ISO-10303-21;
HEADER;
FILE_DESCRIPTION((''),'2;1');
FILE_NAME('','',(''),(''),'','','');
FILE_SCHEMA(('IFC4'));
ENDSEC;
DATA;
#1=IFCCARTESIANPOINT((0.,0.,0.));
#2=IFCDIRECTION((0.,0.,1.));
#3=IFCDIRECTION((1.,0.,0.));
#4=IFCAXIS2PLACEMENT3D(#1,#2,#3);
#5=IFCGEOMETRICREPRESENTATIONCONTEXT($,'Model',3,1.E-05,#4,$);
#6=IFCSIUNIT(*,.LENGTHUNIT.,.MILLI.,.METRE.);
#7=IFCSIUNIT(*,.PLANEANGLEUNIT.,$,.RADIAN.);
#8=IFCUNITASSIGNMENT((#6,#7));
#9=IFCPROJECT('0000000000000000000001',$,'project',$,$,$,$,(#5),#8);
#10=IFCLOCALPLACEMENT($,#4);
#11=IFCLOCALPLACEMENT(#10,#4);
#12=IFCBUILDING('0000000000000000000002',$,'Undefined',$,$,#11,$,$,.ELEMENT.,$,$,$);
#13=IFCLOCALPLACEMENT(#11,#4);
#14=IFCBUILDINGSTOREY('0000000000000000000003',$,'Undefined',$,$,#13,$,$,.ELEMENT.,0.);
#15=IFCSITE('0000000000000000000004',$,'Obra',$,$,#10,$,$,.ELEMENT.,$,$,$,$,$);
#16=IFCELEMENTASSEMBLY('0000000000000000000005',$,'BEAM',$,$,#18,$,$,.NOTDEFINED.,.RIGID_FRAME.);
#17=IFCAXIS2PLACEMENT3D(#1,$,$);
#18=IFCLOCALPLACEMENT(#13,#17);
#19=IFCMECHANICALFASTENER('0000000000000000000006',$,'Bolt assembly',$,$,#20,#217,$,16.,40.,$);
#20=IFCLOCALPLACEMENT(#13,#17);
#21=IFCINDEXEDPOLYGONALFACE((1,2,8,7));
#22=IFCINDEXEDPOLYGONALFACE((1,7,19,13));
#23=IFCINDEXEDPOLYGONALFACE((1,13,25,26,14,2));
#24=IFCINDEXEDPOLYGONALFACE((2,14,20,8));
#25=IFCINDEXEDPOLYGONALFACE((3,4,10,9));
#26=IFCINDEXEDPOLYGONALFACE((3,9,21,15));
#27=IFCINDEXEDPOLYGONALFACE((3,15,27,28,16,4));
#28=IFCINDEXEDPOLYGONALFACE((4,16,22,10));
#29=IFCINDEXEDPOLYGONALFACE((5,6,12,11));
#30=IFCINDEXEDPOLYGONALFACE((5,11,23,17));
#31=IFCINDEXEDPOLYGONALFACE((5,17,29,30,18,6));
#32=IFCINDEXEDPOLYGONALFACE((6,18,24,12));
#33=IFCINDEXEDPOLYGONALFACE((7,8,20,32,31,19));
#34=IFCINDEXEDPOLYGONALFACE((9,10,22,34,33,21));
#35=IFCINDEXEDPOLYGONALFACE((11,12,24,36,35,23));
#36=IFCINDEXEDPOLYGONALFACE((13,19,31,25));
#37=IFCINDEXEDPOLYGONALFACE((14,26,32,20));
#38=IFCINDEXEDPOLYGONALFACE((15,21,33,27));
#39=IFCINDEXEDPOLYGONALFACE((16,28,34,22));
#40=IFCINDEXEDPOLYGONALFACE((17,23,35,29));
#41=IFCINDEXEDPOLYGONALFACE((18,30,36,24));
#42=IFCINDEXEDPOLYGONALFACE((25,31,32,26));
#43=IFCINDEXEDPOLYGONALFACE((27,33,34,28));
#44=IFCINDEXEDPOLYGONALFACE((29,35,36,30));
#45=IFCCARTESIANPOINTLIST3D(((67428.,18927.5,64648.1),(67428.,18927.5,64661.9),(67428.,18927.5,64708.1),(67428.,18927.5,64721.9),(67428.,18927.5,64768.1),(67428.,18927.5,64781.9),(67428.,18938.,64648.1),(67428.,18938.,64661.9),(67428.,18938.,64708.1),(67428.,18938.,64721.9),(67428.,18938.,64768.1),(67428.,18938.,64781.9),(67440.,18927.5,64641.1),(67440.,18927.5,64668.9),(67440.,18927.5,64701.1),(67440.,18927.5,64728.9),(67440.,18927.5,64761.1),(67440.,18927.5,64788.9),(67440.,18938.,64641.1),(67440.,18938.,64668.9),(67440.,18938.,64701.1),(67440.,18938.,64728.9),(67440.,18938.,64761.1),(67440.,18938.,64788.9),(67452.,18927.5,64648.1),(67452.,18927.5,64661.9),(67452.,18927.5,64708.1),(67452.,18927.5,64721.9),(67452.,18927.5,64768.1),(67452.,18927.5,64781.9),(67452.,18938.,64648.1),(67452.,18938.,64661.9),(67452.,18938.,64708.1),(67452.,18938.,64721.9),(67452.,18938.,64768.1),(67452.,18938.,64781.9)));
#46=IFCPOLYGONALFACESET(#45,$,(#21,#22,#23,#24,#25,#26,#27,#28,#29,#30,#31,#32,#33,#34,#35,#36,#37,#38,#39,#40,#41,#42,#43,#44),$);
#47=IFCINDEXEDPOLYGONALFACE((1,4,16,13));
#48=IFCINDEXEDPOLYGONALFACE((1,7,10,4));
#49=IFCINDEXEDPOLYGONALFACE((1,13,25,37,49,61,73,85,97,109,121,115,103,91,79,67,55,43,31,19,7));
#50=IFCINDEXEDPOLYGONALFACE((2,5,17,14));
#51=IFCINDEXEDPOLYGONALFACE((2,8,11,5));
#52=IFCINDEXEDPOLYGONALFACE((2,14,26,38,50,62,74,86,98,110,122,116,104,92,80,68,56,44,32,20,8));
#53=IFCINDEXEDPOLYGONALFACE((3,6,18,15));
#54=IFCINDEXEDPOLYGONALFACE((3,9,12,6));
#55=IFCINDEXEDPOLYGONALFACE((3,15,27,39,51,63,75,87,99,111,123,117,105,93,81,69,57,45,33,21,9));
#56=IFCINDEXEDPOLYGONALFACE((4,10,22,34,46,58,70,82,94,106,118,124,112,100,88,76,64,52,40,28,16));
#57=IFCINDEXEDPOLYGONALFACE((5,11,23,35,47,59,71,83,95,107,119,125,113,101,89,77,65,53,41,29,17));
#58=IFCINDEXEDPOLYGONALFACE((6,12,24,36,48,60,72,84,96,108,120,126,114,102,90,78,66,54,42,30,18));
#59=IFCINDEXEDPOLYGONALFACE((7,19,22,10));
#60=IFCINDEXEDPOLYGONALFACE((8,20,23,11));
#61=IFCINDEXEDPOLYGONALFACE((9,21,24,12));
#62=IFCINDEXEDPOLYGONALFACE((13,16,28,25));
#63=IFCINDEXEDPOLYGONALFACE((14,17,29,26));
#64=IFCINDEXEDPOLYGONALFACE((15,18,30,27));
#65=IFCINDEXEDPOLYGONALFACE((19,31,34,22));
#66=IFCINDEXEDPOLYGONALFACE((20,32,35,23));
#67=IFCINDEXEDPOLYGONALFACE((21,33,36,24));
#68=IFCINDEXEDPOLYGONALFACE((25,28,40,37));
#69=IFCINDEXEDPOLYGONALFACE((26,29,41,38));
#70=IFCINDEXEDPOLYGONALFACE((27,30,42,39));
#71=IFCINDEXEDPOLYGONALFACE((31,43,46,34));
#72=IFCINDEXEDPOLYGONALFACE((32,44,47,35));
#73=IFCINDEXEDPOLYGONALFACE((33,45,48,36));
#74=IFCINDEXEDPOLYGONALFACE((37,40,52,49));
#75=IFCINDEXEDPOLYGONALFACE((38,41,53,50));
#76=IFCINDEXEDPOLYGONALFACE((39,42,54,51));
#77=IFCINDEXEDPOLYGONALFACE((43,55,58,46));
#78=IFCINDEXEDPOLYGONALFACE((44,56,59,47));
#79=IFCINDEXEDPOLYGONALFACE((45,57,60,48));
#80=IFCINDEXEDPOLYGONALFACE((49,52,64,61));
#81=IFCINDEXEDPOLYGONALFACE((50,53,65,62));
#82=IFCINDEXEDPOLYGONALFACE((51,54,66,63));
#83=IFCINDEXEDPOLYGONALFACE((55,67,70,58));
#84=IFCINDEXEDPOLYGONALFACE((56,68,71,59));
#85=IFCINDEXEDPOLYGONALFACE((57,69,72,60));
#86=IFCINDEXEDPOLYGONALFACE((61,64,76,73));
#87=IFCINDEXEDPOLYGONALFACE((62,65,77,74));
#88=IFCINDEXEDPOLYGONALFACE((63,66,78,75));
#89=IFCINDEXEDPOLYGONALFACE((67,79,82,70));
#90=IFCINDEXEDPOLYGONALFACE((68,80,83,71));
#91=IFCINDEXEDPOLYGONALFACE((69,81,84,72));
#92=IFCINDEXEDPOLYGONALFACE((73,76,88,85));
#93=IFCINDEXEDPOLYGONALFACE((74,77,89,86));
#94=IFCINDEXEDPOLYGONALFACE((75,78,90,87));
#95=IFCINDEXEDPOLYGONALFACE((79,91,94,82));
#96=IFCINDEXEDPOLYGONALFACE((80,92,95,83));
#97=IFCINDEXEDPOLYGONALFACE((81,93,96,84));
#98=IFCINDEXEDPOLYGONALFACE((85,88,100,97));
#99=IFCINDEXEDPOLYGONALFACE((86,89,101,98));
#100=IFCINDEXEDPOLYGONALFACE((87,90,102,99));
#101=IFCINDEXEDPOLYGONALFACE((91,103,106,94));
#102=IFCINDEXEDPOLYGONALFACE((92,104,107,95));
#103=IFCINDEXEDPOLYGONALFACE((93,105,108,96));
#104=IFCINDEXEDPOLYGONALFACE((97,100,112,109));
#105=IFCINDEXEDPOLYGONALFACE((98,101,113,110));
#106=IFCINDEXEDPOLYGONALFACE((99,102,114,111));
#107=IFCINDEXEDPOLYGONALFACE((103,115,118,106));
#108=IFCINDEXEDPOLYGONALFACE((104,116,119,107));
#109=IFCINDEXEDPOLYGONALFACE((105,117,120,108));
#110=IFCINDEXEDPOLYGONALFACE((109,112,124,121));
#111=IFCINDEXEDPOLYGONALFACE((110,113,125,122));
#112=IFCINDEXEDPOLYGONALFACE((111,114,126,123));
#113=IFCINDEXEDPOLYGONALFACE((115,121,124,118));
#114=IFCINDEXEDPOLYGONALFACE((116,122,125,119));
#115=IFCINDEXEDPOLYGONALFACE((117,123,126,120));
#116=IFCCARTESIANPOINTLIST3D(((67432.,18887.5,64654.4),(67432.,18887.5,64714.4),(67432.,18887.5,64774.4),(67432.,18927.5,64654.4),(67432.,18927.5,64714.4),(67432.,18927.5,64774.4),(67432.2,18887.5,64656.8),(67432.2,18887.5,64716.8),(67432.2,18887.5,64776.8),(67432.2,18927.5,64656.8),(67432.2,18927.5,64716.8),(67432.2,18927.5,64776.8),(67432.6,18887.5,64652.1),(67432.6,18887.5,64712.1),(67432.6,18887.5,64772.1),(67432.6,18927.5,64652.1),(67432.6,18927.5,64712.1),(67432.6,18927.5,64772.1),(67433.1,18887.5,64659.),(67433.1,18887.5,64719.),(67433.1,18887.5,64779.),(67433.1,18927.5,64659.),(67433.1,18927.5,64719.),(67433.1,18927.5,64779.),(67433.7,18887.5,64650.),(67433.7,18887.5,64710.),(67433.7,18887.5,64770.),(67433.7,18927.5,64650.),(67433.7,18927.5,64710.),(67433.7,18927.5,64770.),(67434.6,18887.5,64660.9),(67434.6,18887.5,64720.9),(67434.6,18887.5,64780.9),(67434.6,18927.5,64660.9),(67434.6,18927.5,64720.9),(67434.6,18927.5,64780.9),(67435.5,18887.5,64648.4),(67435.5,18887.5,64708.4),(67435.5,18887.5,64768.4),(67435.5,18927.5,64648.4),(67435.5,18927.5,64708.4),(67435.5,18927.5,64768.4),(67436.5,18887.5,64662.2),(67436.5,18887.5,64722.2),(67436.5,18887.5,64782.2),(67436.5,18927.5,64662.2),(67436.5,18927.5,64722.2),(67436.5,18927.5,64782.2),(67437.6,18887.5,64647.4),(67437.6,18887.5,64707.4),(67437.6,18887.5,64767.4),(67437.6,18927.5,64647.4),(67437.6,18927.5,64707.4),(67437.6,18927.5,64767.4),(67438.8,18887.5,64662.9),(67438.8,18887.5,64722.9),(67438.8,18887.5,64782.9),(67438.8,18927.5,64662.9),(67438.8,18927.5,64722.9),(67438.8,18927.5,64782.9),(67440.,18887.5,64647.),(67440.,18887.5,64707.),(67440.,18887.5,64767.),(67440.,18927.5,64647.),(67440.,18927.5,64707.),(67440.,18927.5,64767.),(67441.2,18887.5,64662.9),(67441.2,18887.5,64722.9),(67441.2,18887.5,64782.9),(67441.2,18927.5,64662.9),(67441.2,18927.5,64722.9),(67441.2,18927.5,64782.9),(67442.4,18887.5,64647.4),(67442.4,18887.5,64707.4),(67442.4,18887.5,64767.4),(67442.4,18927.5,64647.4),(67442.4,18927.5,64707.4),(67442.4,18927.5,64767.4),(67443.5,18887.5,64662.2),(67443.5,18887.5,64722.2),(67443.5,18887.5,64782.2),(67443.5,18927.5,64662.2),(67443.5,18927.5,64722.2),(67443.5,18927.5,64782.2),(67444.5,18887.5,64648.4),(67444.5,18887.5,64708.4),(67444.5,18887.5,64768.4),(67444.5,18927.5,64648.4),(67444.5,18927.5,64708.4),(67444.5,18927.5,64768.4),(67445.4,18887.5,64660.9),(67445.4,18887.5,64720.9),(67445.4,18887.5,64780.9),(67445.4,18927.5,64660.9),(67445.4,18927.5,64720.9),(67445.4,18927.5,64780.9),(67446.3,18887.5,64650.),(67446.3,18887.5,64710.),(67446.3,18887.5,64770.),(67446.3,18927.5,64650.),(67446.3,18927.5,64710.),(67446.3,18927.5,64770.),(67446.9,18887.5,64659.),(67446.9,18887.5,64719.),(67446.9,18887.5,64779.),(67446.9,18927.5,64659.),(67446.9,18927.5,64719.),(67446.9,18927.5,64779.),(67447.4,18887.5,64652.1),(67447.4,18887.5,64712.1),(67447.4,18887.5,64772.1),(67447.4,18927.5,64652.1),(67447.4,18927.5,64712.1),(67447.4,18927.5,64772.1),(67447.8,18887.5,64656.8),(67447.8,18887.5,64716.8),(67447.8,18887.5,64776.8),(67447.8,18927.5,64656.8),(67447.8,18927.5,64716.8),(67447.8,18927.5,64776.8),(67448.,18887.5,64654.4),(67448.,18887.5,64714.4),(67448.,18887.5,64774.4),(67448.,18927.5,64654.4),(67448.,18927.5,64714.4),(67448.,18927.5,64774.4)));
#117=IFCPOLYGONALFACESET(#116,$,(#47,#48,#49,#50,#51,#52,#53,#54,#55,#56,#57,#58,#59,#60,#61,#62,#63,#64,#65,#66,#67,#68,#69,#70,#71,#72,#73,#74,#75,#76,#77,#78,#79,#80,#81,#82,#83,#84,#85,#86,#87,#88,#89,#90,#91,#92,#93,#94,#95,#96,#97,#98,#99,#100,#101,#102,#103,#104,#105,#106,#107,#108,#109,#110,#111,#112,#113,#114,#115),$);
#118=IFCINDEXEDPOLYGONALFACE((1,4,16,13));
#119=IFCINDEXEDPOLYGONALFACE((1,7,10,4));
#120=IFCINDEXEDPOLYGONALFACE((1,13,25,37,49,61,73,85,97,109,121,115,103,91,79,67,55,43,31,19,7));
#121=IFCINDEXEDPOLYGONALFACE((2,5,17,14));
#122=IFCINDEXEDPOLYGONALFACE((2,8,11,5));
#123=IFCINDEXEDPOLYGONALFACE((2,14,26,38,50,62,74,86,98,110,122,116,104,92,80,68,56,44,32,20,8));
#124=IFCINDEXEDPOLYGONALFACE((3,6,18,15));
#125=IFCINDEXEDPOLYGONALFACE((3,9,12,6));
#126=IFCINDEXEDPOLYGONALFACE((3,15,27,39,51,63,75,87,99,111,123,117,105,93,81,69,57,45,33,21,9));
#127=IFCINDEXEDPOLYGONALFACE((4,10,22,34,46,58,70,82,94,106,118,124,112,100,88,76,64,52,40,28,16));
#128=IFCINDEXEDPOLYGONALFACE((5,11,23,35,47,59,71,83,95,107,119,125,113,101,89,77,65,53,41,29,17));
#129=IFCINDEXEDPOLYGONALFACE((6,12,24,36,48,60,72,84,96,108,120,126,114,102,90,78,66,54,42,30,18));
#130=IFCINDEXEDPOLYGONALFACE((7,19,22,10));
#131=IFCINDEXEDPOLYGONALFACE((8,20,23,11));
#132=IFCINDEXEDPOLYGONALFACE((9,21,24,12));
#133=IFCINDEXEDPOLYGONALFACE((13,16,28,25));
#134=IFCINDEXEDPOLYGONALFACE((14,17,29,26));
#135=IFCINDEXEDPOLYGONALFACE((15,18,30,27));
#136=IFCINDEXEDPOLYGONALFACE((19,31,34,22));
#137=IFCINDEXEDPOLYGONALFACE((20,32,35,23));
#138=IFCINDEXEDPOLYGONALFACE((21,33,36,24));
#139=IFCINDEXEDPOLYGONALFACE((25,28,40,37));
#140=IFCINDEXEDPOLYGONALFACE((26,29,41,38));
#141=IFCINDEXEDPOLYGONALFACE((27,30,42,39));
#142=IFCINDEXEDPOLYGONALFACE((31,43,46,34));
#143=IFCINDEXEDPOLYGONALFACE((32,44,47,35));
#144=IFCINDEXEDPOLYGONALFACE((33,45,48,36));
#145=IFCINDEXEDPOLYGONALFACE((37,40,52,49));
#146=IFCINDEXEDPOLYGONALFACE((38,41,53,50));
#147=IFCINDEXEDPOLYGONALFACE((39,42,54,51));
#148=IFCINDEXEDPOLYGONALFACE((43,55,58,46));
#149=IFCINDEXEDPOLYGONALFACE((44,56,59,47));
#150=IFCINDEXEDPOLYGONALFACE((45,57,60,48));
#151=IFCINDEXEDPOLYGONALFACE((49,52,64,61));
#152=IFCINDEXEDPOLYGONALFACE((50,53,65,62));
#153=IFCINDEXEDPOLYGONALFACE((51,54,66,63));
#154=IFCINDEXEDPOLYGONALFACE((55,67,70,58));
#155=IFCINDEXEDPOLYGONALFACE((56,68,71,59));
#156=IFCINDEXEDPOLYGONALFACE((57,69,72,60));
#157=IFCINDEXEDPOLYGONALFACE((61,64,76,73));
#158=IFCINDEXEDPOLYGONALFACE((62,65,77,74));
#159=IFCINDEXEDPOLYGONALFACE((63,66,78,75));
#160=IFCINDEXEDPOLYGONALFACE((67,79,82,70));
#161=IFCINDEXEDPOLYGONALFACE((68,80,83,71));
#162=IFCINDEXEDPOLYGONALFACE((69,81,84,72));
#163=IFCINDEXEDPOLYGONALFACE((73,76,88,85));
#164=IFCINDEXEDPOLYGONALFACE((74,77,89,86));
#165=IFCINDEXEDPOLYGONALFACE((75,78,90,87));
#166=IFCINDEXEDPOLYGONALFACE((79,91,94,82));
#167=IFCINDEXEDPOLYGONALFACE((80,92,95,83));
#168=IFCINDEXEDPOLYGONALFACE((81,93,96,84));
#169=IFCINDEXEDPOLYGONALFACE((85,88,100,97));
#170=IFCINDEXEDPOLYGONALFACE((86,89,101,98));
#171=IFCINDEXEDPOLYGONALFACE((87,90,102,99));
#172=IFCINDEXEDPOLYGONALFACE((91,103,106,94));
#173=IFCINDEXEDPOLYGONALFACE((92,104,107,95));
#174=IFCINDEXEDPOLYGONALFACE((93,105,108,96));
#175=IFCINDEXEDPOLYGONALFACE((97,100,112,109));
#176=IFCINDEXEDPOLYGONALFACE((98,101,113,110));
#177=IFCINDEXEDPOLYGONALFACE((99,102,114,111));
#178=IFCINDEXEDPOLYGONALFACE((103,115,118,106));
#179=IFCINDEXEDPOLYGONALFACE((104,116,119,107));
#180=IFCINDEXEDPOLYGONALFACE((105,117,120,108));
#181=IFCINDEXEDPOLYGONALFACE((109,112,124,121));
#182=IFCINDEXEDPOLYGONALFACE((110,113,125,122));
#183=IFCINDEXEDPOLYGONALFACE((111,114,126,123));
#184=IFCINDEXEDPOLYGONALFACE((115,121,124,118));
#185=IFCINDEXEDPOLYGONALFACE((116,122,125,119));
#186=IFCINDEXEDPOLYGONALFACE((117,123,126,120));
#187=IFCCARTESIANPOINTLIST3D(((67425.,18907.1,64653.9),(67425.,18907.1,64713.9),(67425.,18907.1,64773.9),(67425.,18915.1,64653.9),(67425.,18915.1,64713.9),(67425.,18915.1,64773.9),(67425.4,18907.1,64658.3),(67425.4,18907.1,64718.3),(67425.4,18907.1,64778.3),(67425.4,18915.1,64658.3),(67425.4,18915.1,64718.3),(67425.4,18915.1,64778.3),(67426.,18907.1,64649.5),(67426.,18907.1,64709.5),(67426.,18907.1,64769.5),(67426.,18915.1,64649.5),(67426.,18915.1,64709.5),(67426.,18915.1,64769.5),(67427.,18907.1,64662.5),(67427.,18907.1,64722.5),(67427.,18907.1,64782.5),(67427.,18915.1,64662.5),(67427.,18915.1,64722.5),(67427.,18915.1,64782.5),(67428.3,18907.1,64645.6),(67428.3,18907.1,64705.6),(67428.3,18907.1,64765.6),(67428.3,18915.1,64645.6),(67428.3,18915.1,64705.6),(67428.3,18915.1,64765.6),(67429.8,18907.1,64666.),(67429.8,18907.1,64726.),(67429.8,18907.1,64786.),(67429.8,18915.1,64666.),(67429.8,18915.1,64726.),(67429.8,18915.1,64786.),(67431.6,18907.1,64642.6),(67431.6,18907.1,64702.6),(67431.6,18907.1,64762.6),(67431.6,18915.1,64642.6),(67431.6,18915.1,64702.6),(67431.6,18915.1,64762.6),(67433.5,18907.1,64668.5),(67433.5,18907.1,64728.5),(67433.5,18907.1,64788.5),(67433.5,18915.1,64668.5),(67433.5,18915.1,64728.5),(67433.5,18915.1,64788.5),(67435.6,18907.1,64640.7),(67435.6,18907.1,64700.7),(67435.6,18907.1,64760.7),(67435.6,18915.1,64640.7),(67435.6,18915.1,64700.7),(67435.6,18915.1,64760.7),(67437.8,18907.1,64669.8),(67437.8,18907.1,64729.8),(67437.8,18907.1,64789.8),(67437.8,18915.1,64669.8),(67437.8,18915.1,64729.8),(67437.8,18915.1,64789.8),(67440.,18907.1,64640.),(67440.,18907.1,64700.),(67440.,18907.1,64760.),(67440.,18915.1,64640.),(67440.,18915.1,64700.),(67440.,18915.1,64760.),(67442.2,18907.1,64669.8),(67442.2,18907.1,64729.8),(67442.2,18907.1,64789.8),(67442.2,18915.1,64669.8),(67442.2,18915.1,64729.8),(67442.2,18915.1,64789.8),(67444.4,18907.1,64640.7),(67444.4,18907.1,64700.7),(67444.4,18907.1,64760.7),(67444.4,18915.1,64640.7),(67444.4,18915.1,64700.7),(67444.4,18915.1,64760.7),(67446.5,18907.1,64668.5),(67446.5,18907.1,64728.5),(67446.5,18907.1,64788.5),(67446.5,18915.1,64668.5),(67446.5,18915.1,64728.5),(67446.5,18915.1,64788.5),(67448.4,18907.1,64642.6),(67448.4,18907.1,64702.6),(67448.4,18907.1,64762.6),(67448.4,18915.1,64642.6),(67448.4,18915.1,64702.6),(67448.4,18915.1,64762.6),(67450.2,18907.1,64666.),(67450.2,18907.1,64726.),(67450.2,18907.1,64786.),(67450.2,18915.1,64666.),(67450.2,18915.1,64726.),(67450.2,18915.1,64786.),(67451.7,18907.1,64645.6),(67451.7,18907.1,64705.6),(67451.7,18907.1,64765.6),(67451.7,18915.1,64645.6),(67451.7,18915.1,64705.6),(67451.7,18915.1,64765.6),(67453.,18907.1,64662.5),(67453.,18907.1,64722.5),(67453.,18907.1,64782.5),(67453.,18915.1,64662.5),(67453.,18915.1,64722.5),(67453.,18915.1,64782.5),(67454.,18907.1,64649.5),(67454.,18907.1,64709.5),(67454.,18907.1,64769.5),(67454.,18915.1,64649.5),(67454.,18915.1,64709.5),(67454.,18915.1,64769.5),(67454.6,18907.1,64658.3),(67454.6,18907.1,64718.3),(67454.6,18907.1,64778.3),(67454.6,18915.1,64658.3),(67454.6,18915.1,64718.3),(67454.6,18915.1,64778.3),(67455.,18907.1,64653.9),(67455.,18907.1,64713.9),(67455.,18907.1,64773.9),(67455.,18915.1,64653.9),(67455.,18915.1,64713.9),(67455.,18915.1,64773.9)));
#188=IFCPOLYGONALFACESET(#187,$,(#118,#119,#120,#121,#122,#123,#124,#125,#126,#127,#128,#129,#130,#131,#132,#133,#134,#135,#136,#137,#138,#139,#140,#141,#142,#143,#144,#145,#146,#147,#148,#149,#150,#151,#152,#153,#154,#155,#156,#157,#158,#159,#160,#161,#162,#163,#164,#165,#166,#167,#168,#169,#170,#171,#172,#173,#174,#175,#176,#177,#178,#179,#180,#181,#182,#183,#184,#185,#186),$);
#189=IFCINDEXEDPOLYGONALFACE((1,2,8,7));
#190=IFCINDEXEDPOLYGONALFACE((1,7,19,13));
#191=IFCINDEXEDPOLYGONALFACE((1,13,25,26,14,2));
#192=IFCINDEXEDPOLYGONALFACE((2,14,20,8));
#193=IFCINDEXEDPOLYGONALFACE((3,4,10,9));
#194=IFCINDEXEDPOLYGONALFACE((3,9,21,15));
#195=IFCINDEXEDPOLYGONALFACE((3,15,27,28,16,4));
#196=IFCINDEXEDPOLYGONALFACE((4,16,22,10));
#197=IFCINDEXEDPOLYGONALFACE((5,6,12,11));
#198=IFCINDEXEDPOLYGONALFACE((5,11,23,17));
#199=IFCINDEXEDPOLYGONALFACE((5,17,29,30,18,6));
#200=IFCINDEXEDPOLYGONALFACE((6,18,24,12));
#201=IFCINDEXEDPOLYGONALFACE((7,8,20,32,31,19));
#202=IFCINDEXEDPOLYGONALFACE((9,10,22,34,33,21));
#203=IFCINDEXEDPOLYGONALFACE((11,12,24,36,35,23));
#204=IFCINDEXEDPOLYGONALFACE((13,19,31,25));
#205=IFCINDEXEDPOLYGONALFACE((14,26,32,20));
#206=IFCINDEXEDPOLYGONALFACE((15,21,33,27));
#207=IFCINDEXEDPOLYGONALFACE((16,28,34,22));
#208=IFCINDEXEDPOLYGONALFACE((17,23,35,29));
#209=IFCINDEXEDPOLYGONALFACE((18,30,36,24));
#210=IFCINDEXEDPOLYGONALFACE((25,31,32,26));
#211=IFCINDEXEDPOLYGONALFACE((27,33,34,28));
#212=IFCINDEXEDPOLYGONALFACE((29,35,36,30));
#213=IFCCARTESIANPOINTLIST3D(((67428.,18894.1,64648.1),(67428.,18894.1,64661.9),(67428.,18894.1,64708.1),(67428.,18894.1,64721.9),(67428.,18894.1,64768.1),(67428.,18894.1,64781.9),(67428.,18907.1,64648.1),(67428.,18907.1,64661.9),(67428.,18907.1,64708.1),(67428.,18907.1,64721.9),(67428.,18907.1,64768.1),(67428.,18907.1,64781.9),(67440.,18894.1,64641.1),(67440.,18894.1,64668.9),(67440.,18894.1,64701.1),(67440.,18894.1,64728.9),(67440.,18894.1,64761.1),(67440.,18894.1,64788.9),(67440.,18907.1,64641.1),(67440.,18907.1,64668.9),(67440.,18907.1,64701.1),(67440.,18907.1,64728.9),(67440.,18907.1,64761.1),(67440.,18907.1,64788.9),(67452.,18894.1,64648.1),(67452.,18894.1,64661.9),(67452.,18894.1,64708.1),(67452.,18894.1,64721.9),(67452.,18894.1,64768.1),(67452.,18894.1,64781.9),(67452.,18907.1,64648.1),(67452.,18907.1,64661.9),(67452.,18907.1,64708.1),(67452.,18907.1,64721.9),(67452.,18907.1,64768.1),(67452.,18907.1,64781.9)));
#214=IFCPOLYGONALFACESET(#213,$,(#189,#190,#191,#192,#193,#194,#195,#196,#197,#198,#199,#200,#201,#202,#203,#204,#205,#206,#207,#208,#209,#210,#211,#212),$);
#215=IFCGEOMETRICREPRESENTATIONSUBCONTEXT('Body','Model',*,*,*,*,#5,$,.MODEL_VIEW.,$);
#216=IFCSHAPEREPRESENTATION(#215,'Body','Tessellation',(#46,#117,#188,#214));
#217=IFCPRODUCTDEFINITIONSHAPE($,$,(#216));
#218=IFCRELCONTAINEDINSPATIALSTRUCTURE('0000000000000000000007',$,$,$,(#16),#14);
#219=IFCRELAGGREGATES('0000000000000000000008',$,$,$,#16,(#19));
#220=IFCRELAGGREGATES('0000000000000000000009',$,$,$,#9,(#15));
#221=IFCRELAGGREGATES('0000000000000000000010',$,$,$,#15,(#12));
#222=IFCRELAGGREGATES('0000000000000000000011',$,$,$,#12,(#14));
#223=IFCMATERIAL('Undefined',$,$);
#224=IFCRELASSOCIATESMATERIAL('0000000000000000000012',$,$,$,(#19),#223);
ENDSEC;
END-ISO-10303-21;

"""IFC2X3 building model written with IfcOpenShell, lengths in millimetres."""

from ifc_helpers import new_model, si_unit, frame, origin_with_axes, origin_2d_with_axis, place, context, subcontext, project, spatial, polyline, circle, outline, extrude, source, transform, mapped, material, element, aggregate, save


model = new_model("IFC2X3")

# Units and contexts
model_context = context("Model", 3, precision=1e-05, world=origin_with_axes())
body_context = subcontext(model_context, "Body", "Model", "MODEL_VIEW")
ifc_project = project(units=[si_unit("LENGTHUNIT", "METRE", prefix="MILLI"), si_unit("PLANEANGLEUNIT", "RADIAN")], contexts=[model_context])

# Site, building, storey
site_placement = place(None, origin_with_axes())
site = spatial("IfcSite", under=ifc_project, at=site_placement, Name="Obra", CompositionType="ELEMENT")
building_placement = place(site_placement, origin_with_axes())
building = spatial("IfcBuilding", under=site, at=building_placement, Name="Undefined", CompositionType="ELEMENT")
storey_placement = place(building_placement, origin_with_axes())
storey = spatial("IfcBuildingStorey", under=building, at=storey_placement, Name="Undefined", CompositionType="ELEMENT", Elevation=0.0)

# Shared definitions
ifc_material_1 = material(Name="Undefined")

# Element assembly, mechanical fastener
shared_shape_1 = source(origin_with_axes(), body_context, "Body", "SweptSolid", [
    extrude(outline(polyline([(13.9, 0.0), (6.9, 12.0), (-6.9, 12.0), (-13.9, 0.0), (-6.9, -12.0), (6.9, -12.0), (13.9, 0.0)])), frame((0.0, -19.7, 0.0), z_axis=(0.0, 1.0, 0.0), x_axis=(1.0, 0.0, 0.0)), (0.0, 0.0, 1.0), 10.6),
    extrude(circle(Radius=8.0, at=origin_2d_with_axis()), frame((0.0, -9.1, 0.0), z_axis=(0.0, 1.0, 0.0), x_axis=(1.0, 0.0, 0.0)), (0.0, 0.0, 1.0), 40.0),
    extrude(circle(Radius=15.0, at=origin_2d_with_axis()), frame((0.0, 3.3, 0.0), z_axis=(0.0, 1.0, 0.0), x_axis=(1.0, 0.0, 0.0)), (0.0, 0.0, 1.0), 8.0),
    extrude(outline(polyline([(13.9, 0.0), (6.9, 12.0), (-6.9, 12.0), (-13.9, 0.0), (-6.9, -12.0), (6.9, -12.0), (13.9, 0.0)])), frame((0.0, 11.3, 0.0), z_axis=(0.0, 1.0, 0.0), x_axis=(1.0, 0.0, 0.0)), (0.0, 0.0, 1.0), 13.0),
])
assembly_1_placement = place(storey_placement, origin_with_axes())
assembly_1 = element("IfcElementAssembly", 1, at=assembly_1_placement, inside=storey, Name="BEAM", AssemblyPlace="NOTDEFINED", PredefinedType="RIGID_FRAME")
mechanical_fastener_1_placement = place(assembly_1_placement, frame((67490.0, 18918.4, 64835.0), z_axis=(-1.0, 0.0, 0.0), x_axis=(0.0, 0.0, -1.0)))
mechanical_fastener_1 = element("IfcMechanicalFastener", 2, at=mechanical_fastener_1_placement, material=ifc_material_1, Name="Bolt assembly", NominalDiameter=16.0, NominalLength=40.0, context=body_context, shape_type="MappedRepresentation", body=[
    mapped(shared_shape_1, transform((60.0, 0.0, 50.0))),
    mapped(shared_shape_1, transform((120.0, 0.0, 50.0))),
    mapped(shared_shape_1, transform((180.0, 0.0, 50.0))),
])
aggregate(assembly_1, [mechanical_fastener_1])

save(model, "model.ifc")
